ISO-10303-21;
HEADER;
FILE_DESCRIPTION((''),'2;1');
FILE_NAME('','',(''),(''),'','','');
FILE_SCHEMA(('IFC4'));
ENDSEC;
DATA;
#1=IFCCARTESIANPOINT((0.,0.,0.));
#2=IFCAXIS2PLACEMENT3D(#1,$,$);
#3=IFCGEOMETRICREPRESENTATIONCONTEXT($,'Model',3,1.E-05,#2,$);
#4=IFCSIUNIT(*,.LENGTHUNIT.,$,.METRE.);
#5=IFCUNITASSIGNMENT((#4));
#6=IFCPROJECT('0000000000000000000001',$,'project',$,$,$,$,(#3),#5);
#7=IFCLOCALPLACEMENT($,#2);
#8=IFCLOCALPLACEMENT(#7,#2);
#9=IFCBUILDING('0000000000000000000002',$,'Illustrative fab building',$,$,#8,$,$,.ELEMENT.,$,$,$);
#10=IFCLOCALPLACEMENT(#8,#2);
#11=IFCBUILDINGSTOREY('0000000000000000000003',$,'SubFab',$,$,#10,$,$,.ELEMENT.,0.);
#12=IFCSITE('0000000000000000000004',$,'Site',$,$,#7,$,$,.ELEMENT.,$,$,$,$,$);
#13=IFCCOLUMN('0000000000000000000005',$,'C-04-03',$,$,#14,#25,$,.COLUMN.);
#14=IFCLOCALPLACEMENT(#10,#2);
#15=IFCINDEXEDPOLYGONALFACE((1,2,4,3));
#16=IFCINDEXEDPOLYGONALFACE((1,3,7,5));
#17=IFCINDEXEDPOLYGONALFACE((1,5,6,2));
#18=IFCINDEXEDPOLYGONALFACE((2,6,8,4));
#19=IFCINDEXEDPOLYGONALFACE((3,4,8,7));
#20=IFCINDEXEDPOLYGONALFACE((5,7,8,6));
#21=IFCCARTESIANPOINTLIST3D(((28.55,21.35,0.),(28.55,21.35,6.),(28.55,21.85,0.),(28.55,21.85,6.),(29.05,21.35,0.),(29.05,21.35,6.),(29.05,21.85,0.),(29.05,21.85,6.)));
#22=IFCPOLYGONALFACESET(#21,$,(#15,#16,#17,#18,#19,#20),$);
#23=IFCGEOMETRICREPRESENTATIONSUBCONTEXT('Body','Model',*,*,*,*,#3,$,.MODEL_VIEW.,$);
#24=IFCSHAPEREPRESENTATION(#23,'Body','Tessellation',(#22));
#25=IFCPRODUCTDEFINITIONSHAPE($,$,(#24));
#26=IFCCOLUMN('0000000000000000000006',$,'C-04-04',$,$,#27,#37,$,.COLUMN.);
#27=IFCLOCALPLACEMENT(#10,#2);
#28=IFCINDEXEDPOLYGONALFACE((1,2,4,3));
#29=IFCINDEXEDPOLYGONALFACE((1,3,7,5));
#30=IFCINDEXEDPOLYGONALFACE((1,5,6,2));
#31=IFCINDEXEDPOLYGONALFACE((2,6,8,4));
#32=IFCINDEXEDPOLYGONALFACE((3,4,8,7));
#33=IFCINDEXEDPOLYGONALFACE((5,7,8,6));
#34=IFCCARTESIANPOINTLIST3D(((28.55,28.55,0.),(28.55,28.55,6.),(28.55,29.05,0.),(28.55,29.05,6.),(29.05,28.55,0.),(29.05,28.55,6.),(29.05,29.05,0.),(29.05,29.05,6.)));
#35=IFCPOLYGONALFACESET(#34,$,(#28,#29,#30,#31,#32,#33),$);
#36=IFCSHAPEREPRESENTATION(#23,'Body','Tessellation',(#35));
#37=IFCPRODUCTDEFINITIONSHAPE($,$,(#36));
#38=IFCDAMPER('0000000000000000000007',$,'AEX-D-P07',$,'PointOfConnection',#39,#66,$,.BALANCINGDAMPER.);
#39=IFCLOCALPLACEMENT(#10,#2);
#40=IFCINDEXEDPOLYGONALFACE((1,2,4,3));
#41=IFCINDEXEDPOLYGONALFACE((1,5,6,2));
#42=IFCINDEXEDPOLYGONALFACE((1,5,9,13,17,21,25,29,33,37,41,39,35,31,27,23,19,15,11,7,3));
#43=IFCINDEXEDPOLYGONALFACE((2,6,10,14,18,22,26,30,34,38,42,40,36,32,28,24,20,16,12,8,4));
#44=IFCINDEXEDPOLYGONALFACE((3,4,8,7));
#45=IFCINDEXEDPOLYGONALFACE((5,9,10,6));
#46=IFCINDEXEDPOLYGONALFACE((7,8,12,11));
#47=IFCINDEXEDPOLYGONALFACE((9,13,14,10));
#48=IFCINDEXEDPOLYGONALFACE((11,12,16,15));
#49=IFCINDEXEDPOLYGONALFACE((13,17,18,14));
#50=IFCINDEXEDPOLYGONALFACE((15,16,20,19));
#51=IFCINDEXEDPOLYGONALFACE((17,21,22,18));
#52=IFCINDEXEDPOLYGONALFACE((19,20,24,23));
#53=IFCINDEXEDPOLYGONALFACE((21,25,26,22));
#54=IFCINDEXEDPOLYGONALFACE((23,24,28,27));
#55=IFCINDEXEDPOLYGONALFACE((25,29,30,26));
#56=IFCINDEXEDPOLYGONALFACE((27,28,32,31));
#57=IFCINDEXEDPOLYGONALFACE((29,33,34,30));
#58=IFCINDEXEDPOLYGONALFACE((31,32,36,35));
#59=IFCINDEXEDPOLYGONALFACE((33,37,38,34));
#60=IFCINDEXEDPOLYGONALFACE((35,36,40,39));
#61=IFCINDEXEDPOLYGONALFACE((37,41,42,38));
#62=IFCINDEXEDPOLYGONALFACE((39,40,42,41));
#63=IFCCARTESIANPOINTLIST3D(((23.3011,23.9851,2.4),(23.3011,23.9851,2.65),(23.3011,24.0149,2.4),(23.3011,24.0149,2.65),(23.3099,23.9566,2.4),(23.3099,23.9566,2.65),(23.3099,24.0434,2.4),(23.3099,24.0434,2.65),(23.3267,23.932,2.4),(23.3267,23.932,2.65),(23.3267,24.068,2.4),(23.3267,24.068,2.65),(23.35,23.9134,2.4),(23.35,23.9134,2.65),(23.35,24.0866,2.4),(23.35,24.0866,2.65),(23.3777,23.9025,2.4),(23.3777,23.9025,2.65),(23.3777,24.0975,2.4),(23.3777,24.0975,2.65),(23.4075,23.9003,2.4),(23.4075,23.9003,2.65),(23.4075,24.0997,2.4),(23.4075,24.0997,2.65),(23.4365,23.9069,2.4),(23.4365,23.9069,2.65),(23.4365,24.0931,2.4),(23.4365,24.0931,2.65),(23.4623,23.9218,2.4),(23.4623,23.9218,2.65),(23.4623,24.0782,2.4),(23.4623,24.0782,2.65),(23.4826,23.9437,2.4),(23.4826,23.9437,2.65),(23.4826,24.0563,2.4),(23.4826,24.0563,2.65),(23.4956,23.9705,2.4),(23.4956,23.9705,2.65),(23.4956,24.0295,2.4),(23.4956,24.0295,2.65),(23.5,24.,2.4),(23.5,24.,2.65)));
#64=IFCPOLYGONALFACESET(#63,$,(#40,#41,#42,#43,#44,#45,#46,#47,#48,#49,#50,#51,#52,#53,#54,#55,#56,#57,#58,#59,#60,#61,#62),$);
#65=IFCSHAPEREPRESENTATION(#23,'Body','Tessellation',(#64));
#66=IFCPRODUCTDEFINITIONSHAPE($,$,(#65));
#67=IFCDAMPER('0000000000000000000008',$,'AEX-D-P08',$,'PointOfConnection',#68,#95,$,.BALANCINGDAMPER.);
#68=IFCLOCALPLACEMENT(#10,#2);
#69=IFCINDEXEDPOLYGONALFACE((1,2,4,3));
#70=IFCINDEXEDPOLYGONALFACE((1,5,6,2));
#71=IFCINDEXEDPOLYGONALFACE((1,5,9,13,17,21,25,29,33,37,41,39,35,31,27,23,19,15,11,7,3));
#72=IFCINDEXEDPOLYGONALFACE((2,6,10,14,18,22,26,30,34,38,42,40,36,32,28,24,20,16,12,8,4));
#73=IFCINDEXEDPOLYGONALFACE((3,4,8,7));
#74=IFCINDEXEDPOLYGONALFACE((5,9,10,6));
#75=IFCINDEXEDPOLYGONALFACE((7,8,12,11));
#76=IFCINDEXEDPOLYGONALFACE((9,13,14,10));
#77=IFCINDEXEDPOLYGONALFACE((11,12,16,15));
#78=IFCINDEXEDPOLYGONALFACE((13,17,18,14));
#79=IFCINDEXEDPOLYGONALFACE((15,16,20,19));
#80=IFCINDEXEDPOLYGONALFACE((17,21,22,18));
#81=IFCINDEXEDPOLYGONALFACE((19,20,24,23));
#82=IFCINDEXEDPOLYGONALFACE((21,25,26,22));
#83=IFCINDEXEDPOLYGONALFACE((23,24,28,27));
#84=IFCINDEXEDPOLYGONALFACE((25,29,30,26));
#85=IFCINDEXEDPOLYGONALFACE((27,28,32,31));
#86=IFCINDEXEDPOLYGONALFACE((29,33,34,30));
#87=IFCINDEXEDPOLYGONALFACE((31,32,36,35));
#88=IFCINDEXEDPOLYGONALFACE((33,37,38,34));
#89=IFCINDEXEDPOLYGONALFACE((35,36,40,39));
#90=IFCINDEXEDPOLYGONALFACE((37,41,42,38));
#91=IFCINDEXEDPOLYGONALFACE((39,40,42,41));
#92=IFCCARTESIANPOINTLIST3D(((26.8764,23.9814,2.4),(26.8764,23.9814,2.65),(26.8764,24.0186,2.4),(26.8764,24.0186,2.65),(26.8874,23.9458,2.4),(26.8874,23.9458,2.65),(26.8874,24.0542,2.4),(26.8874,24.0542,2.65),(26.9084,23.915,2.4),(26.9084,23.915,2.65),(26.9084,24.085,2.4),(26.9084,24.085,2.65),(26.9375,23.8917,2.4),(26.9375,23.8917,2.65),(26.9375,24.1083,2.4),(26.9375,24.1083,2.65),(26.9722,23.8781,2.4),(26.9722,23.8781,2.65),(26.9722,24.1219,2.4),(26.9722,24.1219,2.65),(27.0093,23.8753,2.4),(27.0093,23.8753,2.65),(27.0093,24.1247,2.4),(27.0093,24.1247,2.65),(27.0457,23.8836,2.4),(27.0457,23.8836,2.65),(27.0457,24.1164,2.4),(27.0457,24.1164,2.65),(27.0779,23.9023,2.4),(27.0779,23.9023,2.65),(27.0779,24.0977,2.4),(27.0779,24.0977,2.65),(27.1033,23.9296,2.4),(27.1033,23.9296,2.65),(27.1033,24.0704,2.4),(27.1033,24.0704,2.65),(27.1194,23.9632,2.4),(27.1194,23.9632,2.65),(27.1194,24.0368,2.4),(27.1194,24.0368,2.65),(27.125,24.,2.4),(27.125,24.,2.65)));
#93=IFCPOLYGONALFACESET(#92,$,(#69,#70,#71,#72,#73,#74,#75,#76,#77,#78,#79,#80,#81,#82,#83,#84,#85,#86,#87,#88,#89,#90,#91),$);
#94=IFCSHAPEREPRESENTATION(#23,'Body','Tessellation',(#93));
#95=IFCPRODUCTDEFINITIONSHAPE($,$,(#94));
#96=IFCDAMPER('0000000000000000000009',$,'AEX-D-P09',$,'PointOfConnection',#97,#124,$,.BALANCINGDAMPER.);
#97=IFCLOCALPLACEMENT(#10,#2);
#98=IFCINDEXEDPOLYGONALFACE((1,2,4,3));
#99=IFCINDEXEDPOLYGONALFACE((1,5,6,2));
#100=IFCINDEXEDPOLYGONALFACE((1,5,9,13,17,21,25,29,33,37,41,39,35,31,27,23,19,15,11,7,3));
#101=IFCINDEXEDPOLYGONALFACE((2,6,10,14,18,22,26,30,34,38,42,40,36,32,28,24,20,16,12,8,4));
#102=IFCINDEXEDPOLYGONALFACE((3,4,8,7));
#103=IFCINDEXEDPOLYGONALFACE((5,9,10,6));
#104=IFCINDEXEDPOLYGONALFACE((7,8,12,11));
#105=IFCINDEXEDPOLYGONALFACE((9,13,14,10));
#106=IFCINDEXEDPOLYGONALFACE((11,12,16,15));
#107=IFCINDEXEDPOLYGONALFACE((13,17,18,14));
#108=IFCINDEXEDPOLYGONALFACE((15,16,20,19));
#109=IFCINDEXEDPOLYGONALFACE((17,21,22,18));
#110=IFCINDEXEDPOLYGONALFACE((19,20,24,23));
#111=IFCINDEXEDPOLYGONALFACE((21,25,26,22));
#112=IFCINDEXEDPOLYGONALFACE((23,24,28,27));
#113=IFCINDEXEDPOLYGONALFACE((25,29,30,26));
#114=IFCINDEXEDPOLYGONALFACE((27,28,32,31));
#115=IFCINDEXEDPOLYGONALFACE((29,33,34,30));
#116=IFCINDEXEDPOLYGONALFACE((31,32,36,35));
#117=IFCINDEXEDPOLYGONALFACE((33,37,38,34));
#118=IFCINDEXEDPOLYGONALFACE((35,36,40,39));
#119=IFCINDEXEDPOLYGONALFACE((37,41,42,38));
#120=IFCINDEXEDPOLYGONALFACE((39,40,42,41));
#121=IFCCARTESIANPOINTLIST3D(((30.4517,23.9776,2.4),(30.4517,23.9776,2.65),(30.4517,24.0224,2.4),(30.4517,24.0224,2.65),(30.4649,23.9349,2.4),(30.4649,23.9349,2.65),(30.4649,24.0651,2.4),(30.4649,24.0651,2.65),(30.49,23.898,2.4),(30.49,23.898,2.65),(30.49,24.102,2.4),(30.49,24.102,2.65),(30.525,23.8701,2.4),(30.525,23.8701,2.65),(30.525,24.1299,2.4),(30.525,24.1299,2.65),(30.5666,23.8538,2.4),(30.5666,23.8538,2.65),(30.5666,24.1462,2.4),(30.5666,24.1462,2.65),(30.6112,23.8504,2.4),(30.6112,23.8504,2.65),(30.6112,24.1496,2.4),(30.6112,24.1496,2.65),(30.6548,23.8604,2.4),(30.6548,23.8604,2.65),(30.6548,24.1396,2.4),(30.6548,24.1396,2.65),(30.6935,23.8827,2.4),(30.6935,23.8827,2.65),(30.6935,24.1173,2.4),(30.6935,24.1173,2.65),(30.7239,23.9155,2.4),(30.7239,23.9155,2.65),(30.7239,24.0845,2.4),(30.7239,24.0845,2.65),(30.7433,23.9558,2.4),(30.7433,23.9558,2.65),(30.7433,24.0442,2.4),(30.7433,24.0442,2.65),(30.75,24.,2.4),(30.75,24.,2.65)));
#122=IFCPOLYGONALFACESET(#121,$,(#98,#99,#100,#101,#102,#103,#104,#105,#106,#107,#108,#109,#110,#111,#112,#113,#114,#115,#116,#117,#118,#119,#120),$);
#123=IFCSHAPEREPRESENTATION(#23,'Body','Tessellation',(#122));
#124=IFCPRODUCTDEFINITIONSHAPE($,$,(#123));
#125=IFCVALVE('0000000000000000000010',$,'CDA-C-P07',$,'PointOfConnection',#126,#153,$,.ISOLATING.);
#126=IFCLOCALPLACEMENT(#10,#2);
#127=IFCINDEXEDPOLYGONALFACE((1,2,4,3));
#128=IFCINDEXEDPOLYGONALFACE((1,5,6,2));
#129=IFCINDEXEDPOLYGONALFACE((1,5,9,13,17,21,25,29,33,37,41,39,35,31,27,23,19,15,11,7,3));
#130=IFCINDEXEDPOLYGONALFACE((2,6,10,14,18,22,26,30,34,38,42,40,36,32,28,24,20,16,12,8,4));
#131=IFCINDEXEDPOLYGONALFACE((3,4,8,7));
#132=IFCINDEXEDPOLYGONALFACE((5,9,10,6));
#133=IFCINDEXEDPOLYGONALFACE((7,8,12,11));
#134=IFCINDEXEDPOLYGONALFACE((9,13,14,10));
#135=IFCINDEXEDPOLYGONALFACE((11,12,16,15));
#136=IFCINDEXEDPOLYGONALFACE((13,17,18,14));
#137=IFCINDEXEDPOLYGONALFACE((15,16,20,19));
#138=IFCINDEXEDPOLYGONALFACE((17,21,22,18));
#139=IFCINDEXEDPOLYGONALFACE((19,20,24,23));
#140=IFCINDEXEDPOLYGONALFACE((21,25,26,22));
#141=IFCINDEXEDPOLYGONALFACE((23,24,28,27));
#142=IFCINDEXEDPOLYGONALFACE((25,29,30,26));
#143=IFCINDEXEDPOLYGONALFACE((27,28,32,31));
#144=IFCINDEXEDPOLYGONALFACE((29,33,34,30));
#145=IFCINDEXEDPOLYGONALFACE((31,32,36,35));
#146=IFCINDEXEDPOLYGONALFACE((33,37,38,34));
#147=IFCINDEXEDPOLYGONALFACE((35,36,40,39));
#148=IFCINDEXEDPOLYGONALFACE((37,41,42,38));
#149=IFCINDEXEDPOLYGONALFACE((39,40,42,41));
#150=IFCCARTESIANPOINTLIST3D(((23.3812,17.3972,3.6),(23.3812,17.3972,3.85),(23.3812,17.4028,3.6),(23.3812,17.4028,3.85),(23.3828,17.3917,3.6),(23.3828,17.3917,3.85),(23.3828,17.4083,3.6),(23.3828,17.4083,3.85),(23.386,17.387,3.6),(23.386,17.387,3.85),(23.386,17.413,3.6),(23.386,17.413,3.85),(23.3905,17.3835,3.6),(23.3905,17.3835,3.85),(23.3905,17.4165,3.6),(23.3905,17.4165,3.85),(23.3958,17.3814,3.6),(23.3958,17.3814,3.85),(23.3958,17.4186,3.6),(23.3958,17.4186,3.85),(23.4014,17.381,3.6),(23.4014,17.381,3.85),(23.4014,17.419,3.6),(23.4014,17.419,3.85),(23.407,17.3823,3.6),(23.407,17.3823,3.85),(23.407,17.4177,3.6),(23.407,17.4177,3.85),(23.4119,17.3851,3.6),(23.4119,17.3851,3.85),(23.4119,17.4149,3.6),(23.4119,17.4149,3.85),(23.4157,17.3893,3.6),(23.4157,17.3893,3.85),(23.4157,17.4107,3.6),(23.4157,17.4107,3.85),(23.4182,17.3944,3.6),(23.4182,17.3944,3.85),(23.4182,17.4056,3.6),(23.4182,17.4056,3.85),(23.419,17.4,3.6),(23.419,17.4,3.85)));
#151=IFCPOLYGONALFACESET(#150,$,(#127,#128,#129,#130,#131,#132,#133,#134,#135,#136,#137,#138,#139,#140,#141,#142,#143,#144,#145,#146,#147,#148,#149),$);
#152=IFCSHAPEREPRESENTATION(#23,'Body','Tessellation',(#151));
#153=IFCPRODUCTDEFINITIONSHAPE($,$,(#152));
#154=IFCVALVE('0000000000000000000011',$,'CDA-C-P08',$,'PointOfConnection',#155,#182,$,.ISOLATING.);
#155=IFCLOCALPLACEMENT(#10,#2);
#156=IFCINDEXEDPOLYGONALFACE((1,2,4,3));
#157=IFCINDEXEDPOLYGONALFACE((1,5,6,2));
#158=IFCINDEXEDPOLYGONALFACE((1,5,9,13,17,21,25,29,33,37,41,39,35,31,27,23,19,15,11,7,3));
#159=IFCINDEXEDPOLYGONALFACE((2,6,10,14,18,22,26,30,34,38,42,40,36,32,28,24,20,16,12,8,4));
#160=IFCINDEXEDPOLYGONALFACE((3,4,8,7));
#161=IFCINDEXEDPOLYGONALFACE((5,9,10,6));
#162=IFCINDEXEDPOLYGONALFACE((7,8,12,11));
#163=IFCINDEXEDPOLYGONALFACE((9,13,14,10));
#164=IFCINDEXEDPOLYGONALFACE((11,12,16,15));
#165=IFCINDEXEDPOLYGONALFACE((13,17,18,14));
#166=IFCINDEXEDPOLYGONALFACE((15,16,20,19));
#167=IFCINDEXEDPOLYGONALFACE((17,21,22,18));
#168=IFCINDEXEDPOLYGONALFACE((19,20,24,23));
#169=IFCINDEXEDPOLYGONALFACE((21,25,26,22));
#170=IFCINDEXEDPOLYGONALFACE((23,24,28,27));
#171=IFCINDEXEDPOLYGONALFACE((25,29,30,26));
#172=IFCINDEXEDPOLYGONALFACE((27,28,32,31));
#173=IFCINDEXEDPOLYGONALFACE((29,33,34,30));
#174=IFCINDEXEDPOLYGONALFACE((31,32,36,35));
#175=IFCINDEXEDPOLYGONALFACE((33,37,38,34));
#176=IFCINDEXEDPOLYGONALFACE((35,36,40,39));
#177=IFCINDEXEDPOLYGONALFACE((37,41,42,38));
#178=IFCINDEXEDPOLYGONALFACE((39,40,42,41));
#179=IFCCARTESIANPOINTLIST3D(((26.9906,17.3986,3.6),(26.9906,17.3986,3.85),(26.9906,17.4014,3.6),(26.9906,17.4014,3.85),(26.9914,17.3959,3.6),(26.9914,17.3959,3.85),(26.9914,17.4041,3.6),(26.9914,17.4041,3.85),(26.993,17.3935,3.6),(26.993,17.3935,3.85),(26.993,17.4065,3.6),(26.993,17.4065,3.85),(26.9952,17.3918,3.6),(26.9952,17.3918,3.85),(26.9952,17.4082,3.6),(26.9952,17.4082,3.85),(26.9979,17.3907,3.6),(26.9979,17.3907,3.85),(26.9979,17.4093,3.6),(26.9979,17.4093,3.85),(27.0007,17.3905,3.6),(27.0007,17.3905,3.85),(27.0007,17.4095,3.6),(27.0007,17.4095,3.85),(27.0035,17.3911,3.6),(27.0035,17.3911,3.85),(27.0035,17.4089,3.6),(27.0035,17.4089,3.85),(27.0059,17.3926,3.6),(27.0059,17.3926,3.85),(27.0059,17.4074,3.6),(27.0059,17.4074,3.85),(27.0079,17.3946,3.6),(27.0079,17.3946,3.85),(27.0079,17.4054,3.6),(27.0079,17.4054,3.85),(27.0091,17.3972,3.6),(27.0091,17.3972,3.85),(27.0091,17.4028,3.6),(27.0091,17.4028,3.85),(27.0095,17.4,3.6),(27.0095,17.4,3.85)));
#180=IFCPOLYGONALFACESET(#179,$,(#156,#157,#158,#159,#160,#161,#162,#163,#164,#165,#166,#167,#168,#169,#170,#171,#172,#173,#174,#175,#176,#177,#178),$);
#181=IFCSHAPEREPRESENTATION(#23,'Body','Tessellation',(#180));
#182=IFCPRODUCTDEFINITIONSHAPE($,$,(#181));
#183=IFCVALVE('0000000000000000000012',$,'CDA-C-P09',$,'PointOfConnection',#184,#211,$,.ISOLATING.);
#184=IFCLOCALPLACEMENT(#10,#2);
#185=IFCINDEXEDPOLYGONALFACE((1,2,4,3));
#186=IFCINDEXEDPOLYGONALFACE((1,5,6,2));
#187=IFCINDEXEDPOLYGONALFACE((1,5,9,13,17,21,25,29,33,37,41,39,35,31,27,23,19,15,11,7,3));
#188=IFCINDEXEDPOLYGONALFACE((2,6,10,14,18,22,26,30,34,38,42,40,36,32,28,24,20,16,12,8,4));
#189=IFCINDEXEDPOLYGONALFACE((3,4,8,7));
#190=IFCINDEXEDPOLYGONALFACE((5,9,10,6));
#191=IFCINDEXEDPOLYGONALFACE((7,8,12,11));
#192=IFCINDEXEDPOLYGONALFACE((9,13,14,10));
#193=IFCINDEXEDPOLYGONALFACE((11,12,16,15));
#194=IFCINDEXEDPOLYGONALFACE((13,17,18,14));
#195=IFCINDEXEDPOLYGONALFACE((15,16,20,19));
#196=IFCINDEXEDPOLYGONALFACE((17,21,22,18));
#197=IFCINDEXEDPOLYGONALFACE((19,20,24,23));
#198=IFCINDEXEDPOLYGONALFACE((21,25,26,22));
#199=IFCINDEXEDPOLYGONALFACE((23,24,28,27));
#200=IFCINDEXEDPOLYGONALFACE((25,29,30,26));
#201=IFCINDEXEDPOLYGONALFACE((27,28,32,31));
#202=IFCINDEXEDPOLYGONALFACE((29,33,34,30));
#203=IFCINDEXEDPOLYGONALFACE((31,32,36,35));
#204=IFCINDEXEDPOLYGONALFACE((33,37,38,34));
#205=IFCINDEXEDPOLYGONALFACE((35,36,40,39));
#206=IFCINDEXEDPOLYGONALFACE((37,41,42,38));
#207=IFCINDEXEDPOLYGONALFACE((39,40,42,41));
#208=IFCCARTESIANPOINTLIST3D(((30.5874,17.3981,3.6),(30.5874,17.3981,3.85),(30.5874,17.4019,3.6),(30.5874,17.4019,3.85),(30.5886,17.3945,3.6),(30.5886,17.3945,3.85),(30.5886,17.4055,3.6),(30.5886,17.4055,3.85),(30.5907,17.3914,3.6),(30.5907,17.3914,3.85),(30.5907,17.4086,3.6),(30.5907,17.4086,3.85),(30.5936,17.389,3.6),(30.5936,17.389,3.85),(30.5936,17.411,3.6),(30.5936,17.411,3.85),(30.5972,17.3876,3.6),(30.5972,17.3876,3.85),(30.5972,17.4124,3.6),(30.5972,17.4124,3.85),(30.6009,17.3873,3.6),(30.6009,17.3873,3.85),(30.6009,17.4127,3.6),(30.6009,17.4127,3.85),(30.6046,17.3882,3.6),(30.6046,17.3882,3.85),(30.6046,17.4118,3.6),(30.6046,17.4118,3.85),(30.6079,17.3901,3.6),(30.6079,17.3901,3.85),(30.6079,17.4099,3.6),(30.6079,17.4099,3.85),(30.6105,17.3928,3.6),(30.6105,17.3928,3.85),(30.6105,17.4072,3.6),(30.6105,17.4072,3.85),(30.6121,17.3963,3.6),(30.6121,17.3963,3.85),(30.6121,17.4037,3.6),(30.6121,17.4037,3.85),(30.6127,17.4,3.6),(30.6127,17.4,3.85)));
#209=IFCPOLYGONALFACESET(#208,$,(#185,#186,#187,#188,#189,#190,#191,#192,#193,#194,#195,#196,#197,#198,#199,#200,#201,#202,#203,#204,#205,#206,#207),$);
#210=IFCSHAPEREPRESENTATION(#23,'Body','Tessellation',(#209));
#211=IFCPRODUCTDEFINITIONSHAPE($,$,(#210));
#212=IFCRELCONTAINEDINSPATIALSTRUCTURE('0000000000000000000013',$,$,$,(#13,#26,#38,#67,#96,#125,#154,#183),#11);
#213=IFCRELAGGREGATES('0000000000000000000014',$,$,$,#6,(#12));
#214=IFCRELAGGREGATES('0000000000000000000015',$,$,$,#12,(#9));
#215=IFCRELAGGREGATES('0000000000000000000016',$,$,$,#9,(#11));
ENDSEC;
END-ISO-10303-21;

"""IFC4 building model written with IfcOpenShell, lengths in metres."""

from ifc_helpers import new_model, entity, si_unit, frame, origin, origin_2d, place, context, subcontext, project, spatial, rectangle, extrude, element, save


model = new_model("IFC4")

# Units and contexts
model_context = context("Model", 3, precision=1e-05, world=origin())
body_context = subcontext(model_context, "Body", "Model", "MODEL_VIEW")
ifc_project = project(units=[si_unit("LENGTHUNIT", "METRE")], contexts=[model_context])

# Site, building, storey
site_placement = place(None, origin())
site = spatial("IfcSite", under=ifc_project, at=site_placement, Name="Site", CompositionType="ELEMENT")
building_placement = place(site_placement, origin())
building = spatial("IfcBuilding", under=site, at=building_placement, Name="Illustrative fab building", CompositionType="ELEMENT")
storey_placement = place(building_placement, origin())
storey = spatial("IfcBuildingStorey", under=building, at=storey_placement, Name="SubFab", CompositionType="ELEMENT", Elevation=0.0)

# Columns
for number, where, name in (
    (1, (28.8, 21.6, 0.0), "C-04-03"),
    (2, (28.8, 28.8, 0.0), "C-04-04"),
):
    element("IfcColumn", number, at=place(storey_placement, frame(where)), inside=storey, Name=name, PredefinedType="COLUMN", context=body_context, shape_type="SweptSolid", body=[
        extrude(rectangle(XDim=0.5, YDim=0.5, at=origin_2d()), origin(), (0.0, 0.0, 1.0), 6.0),
    ])

# Dampers
damper_1_placement = place(storey_placement, frame((23.4, 24.0, 2.4)))
element("IfcDamper", 3, at=damper_1_placement, inside=storey, Name="AEX-D-P07", ObjectType="PointOfConnection", PredefinedType="BALANCINGDAMPER", context=body_context, shape_type="AdvancedSweptSolid", body=[
    entity("IfcSweptDiskSolid", entity("IfcPolyline", [entity("IfcCartesianPoint", [0.0, 0.0, 0.0]), entity("IfcCartesianPoint", [0.0, 0.0, 0.25])]), 0.1),
])
damper_2_placement = place(storey_placement, frame((27.0, 24.0, 2.4)))
element("IfcDamper", 4, at=damper_2_placement, inside=storey, Name="AEX-D-P08", ObjectType="PointOfConnection", PredefinedType="BALANCINGDAMPER", context=body_context, shape_type="AdvancedSweptSolid", body=[
    entity("IfcSweptDiskSolid", entity("IfcPolyline", [entity("IfcCartesianPoint", [0.0, 0.0, 0.0]), entity("IfcCartesianPoint", [0.0, 0.0, 0.25])]), 0.125),
])
damper_3_placement = place(storey_placement, frame((30.6, 24.0, 2.4)))
element("IfcDamper", 5, at=damper_3_placement, inside=storey, Name="AEX-D-P09", ObjectType="PointOfConnection", PredefinedType="BALANCINGDAMPER", context=body_context, shape_type="AdvancedSweptSolid", body=[
    entity("IfcSweptDiskSolid", entity("IfcPolyline", [entity("IfcCartesianPoint", [0.0, 0.0, 0.0]), entity("IfcCartesianPoint", [0.0, 0.0, 0.25])]), 0.15),
])

# Valves
valve_1_placement = place(storey_placement, frame((23.4, 17.4, 3.6)))
element("IfcValve", 6, at=valve_1_placement, inside=storey, Name="CDA-C-P07", ObjectType="PointOfConnection", PredefinedType="ISOLATING", context=body_context, shape_type="AdvancedSweptSolid", body=[
    entity("IfcSweptDiskSolid", entity("IfcPolyline", [entity("IfcCartesianPoint", [0.0, 0.0, 0.0]), entity("IfcCartesianPoint", [0.0, 0.0, 0.25])]), 0.019),
])
valve_2_placement = place(storey_placement, frame((27.0, 17.4, 3.6)))
element("IfcValve", 7, at=valve_2_placement, inside=storey, Name="CDA-C-P08", ObjectType="PointOfConnection", PredefinedType="ISOLATING", context=body_context, shape_type="AdvancedSweptSolid", body=[
    entity("IfcSweptDiskSolid", entity("IfcPolyline", [entity("IfcCartesianPoint", [0.0, 0.0, 0.0]), entity("IfcCartesianPoint", [0.0, 0.0, 0.25])]), 0.0095),
])
valve_3_placement = place(storey_placement, frame((30.6, 17.4, 3.6)))
element("IfcValve", 8, at=valve_3_placement, inside=storey, Name="CDA-C-P09", ObjectType="PointOfConnection", PredefinedType="ISOLATING", context=body_context, shape_type="AdvancedSweptSolid", body=[
    entity("IfcSweptDiskSolid", entity("IfcPolyline", [entity("IfcCartesianPoint", [0.0, 0.0, 0.0]), entity("IfcCartesianPoint", [0.0, 0.0, 0.25])]), 0.0127),
])

save(model, "model.ifc")
